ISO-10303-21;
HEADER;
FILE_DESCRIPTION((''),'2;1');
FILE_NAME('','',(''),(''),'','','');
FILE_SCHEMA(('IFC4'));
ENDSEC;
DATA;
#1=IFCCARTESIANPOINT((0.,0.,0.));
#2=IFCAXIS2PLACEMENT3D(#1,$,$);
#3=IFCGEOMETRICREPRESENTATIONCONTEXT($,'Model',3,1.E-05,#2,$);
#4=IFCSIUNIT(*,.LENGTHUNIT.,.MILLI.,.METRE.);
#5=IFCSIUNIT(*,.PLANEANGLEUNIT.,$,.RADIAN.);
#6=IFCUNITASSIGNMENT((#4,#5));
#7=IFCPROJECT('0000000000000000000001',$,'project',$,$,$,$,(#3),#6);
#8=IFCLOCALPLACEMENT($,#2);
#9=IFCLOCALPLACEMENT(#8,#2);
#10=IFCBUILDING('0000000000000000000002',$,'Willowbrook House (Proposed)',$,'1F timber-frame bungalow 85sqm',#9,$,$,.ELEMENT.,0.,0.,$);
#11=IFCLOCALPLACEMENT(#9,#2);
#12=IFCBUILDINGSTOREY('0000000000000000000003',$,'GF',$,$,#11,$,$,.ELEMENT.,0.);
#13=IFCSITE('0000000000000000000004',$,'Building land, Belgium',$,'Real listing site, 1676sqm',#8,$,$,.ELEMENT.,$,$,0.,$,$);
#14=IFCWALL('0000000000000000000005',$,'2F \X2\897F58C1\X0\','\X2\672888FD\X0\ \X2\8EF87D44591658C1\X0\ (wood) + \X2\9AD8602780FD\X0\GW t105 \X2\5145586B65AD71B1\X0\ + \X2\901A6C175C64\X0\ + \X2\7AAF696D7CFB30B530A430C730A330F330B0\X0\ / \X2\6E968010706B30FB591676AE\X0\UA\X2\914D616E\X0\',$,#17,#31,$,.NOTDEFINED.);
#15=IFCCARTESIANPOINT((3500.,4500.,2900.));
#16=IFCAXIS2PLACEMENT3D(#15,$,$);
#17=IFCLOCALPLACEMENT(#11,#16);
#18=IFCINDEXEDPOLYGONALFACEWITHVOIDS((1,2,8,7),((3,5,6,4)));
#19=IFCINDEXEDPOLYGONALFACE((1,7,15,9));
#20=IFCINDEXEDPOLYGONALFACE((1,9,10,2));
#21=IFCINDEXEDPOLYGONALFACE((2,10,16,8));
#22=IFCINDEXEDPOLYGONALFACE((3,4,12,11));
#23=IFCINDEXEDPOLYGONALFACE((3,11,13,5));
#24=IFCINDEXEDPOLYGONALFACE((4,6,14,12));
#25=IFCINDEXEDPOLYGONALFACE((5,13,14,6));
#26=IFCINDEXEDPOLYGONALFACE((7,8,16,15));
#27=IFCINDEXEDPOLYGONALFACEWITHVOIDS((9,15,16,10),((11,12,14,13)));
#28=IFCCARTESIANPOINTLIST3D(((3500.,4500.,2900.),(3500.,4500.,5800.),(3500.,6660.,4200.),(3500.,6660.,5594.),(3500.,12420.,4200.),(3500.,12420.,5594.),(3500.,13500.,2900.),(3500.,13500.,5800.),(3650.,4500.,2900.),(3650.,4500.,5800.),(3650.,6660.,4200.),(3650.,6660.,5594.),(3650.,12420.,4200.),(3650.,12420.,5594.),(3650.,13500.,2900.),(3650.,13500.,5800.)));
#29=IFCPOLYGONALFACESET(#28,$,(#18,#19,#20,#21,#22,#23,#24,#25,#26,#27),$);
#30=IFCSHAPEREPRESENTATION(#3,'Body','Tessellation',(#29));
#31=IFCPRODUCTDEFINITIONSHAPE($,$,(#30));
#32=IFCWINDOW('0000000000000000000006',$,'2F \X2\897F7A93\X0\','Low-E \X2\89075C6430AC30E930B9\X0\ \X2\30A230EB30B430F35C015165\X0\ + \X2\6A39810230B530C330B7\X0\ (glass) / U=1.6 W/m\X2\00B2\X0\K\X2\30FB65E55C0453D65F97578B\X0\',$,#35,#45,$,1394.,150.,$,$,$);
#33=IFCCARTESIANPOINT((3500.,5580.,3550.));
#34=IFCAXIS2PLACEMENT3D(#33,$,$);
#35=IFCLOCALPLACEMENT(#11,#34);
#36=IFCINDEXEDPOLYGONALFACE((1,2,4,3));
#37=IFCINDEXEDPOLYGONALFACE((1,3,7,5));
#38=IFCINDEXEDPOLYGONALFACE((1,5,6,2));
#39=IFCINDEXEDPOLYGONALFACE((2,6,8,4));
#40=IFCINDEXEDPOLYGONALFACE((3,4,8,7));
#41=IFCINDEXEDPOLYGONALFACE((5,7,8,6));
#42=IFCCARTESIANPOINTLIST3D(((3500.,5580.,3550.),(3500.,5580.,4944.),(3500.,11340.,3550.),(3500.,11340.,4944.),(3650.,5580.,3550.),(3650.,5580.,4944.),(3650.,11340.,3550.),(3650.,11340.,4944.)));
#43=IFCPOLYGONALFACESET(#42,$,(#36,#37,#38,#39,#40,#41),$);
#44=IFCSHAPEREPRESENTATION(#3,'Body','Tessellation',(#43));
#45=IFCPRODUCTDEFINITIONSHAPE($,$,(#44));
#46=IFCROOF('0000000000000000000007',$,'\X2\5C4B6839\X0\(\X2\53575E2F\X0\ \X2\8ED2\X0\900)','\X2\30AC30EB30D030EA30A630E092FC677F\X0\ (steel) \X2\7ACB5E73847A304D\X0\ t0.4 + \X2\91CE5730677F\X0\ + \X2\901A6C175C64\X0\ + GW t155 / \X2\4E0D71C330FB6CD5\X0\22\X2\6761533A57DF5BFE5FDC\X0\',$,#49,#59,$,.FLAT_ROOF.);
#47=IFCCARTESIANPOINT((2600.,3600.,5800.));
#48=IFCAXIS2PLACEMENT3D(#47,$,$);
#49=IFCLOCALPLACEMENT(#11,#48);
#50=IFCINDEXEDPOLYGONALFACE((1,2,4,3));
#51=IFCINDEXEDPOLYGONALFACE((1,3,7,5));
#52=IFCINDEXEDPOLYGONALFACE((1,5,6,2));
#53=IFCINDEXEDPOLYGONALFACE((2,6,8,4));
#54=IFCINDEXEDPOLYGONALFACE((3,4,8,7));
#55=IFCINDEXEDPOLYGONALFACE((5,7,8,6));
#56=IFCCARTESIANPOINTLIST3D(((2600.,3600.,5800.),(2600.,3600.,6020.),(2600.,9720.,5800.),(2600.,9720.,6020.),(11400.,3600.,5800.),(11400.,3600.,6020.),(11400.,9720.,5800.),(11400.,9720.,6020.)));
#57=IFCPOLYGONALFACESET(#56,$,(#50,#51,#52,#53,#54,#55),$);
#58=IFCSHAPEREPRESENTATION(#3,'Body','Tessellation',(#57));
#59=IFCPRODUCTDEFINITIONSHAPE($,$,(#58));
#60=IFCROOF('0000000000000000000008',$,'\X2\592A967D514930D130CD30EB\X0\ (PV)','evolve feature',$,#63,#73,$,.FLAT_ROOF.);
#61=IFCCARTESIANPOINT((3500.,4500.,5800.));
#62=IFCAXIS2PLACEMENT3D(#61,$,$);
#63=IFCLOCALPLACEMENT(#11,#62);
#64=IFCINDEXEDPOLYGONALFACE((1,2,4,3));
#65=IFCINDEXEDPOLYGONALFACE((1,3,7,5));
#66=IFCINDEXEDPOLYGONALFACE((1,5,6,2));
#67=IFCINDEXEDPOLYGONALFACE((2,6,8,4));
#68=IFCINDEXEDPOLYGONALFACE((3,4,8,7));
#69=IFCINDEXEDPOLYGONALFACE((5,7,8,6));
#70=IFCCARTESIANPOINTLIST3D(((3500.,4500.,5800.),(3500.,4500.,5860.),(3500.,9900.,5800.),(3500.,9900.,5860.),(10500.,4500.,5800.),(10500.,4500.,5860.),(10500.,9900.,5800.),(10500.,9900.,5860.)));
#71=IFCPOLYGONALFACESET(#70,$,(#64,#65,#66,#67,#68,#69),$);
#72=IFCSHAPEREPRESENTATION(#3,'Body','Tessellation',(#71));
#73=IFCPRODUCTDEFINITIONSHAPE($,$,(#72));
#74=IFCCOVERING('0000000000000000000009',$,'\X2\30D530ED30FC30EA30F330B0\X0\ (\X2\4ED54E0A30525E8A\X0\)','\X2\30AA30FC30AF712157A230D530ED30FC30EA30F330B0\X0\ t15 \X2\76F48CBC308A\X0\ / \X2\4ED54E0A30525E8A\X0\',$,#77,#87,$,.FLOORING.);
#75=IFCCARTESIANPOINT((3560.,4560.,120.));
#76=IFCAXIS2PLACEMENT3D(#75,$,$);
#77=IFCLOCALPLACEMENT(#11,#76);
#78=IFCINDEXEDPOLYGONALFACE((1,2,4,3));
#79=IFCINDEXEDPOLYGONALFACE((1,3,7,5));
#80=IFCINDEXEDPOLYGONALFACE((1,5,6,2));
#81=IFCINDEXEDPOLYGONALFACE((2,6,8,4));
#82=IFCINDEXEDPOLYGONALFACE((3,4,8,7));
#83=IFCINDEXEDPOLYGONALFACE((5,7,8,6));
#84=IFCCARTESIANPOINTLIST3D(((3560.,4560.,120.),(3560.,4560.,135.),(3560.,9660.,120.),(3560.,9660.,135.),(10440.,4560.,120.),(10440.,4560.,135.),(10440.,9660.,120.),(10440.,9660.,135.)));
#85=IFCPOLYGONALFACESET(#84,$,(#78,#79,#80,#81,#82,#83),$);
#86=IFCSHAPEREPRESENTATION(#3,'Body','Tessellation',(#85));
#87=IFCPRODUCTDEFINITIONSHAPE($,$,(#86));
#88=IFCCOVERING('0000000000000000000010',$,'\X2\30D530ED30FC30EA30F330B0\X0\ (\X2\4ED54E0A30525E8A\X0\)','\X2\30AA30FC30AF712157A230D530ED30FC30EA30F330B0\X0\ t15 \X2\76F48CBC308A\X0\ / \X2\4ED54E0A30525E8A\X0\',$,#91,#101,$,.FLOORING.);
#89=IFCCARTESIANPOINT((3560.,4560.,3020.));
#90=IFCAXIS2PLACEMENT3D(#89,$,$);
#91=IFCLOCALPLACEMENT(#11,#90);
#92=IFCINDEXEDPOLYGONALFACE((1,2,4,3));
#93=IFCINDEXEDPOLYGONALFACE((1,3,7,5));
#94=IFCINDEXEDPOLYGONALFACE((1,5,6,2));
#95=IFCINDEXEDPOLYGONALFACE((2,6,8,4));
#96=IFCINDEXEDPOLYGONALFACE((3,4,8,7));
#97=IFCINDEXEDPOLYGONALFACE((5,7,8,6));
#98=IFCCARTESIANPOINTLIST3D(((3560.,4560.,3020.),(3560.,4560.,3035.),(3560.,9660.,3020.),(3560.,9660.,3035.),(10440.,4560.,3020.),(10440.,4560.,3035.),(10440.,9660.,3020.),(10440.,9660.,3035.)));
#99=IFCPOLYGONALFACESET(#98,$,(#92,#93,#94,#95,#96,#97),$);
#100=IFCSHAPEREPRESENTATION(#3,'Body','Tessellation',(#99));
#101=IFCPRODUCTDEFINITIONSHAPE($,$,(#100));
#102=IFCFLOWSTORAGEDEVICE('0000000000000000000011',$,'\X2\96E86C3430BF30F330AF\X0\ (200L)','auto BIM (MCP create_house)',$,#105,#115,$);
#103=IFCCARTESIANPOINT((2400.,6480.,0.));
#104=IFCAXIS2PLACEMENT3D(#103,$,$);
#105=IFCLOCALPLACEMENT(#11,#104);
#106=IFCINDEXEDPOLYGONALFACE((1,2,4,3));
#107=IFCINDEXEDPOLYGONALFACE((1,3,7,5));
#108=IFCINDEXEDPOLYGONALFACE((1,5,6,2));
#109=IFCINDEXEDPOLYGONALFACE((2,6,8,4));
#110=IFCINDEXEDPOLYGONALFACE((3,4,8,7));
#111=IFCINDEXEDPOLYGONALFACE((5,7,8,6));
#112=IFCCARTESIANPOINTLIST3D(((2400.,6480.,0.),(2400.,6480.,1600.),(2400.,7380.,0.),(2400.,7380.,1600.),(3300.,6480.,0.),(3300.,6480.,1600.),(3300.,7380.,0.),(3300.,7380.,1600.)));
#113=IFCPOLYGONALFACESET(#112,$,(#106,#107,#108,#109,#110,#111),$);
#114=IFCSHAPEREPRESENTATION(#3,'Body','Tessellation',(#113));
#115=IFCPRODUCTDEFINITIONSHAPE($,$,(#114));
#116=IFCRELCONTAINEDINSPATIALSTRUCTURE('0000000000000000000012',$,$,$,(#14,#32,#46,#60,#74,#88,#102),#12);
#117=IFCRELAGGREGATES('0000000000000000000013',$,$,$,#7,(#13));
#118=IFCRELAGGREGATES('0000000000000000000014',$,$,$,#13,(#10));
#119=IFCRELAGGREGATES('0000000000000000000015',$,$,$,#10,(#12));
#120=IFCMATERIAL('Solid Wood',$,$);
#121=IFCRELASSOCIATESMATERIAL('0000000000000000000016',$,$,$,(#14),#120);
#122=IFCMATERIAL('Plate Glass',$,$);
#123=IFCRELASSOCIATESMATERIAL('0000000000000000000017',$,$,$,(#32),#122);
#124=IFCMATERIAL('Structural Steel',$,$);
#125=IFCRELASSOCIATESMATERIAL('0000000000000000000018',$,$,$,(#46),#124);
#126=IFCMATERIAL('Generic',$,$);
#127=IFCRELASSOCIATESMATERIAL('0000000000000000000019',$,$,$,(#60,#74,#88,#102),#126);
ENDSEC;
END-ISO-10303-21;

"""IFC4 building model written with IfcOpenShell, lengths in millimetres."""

from ifc_helpers import new_model, si_unit, frame, frame_2d, origin, place, context, project, spatial, rectangle, extrude, material, element, fill, save


model = new_model("IFC4")

# Units and contexts
model_context = context("Model", 3, precision=1e-05, world=origin())
ifc_project = project(units=[si_unit("LENGTHUNIT", "METRE", prefix="MILLI"), si_unit("PLANEANGLEUNIT", "RADIAN")], contexts=[model_context])

# Site, building, storey
site_placement = place(None, origin())
site = spatial("IfcSite", under=ifc_project, at=site_placement, Name="Building land, Belgium", ObjectType="Real listing site, 1676sqm", CompositionType="ELEMENT", RefElevation=0.0)
building_placement = place(site_placement, origin())
building = spatial("IfcBuilding", under=site, at=building_placement, Name="Willowbrook House (Proposed)", ObjectType="1F timber-frame bungalow 85sqm", CompositionType="ELEMENT", ElevationOfRefHeight=0.0, ElevationOfTerrain=0.0)
storey_placement = place(building_placement, origin())
storey = spatial("IfcBuildingStorey", under=building, at=storey_placement, Name="GF", CompositionType="ELEMENT", Elevation=0.0)

# Shared definitions
ifc_material_1 = material(Name="Solid Wood")
ifc_material_2 = material(Name="Generic")

# Shared definitions
ifc_material_3 = material(Name="Plate Glass")

# Wall, opening, window
wall_1_placement = place(storey_placement, frame((3500.0, 4500.0, 2900.0)))
wall_1 = element("IfcWall", 1, at=wall_1_placement, inside=storey, material=ifc_material_1, Name="2F 西壁", Description="木製 軸組外壁 (wood) + 高性能GW t105 充填断熱 + 通気層 + 窯業系サイディング / 準耐火・外皮UA配慮", PredefinedType="NOTDEFINED", context=model_context, shape_type="SweptSolid", body=[
    extrude(rectangle(XDim=150.0, YDim=9000.0, at=frame_2d((75.0, 4500.0))), frame((3500.0, 4500.0, 2900.0)), (0.0, 0.0, 1.0), 2900.0),
])
opening_1_placement = place(storey_placement, frame((3500.0, 5580.0, 3550.0)))
opening_1 = element("IfcOpeningElement", 2, at=opening_1_placement, cuts=wall_1, PredefinedType="NOTDEFINED", context=model_context, shape_type="SweptSolid", body=[
    extrude(rectangle(XDim=150.0, YDim=5760.0, at=frame_2d((75.0, 2880.0))), frame((3500.0, 5580.0, 3550.0)), (0.0, 0.0, 1.0), 1394.0),
])
window_1_placement = place(storey_placement, frame((3500.0, 5580.0, 3550.0)))
window_1 = element("IfcWindow", 3, at=window_1_placement, inside=storey, material=ifc_material_3, Name="2F 西窓", Description="Low-E 複層ガラス アルゴン封入 + 樹脂サッシ (glass) / U=1.6 W/m²K・日射取得型", OverallHeight=1394.0, OverallWidth=150.0, context=model_context, shape_type="SweptSolid", body=[
    extrude(rectangle(XDim=150.0, YDim=5760.0, at=frame_2d((75.0, 2880.0))), frame((3500.0, 5580.0, 3550.0)), (0.0, 0.0, 1.0), 1394.0),
])
fill(opening_1, window_1)

# Roofs
ifc_material_4 = material(Name="Structural Steel")
for number, where, name in (
    (4, (2600.0, 3600.0, 5800.0), "屋根(南帯 軒900)"),
):
    element("IfcRoof", number, at=place(storey_placement, frame(where)), inside=storey, material=ifc_material_4, Name=name, Description="ガルバリウム鋼板 (steel) 立平葺き t0.4 + 野地板 + 通気層 + GW t155 / 不燃・法22条区域対応", PredefinedType="FLAT_ROOF", context=model_context, shape_type="SweptSolid", body=[
        extrude(rectangle(XDim=8800.0, YDim=6120.0, at=frame_2d((4400.0, 3060.0))), frame((2600.0, 3600.0, 5800.0)), (0.0, 0.0, 1.0), 220.0),
    ])
roof_placement = place(storey_placement, frame((3500.0, 4500.0, 5800.0)))
element("IfcRoof", 5, at=roof_placement, inside=storey, material=ifc_material_2, Name="太陽光パネル (PV)", Description="evolve feature", PredefinedType="FLAT_ROOF", context=model_context, shape_type="SweptSolid", body=[
    extrude(rectangle(XDim=7000.0, YDim=5400.0, at=frame_2d((3500.0, 2700.0))), frame((3500.0, 4500.0, 5800.0)), (0.0, 0.0, 1.0), 60.0),
])

# Coverings
covering_1_placement = place(storey_placement, frame((3560.0, 4560.0, 120.0)))
element("IfcCovering", 6, at=covering_1_placement, inside=storey, material=ifc_material_2, Name="フローリング (仕上げ床)", Description="オーク無垢フローリング t15 直貼り / 仕上げ床", PredefinedType="FLOORING", context=model_context, shape_type="SweptSolid", body=[
    extrude(rectangle(XDim=6880.0, YDim=5100.0, at=frame_2d((3440.0, 2550.0))), frame((3560.0, 4560.0, 120.0)), (0.0, 0.0, 1.0), 15.0),
])
covering_2_placement = place(storey_placement, frame((3560.0, 4560.0, 3020.0)))
element("IfcCovering", 7, at=covering_2_placement, inside=storey, material=ifc_material_2, Name="フローリング (仕上げ床)", Description="オーク無垢フローリング t15 直貼り / 仕上げ床", PredefinedType="FLOORING", context=model_context, shape_type="SweptSolid", body=[
    extrude(rectangle(XDim=6880.0, YDim=5100.0, at=frame_2d((3440.0, 2550.0))), frame((3560.0, 4560.0, 3020.0)), (0.0, 0.0, 1.0), 15.0),
])

# Flow storage device
flow_storage_device_placement = place(storey_placement, frame((2400.0, 6480.0, 0.0)))
element("IfcFlowStorageDevice", 8, at=flow_storage_device_placement, inside=storey, material=ifc_material_2, Name="雨水タンク (200L)", Description="auto BIM (MCP create_house)", context=model_context, shape_type="SweptSolid", body=[
    extrude(rectangle(XDim=900.0, YDim=900.0, at=frame_2d((450.0, 450.0))), frame((2400.0, 6480.0, 0.0)), (0.0, 0.0, 1.0), 1600.0),
])

save(model, "model.ifc")
